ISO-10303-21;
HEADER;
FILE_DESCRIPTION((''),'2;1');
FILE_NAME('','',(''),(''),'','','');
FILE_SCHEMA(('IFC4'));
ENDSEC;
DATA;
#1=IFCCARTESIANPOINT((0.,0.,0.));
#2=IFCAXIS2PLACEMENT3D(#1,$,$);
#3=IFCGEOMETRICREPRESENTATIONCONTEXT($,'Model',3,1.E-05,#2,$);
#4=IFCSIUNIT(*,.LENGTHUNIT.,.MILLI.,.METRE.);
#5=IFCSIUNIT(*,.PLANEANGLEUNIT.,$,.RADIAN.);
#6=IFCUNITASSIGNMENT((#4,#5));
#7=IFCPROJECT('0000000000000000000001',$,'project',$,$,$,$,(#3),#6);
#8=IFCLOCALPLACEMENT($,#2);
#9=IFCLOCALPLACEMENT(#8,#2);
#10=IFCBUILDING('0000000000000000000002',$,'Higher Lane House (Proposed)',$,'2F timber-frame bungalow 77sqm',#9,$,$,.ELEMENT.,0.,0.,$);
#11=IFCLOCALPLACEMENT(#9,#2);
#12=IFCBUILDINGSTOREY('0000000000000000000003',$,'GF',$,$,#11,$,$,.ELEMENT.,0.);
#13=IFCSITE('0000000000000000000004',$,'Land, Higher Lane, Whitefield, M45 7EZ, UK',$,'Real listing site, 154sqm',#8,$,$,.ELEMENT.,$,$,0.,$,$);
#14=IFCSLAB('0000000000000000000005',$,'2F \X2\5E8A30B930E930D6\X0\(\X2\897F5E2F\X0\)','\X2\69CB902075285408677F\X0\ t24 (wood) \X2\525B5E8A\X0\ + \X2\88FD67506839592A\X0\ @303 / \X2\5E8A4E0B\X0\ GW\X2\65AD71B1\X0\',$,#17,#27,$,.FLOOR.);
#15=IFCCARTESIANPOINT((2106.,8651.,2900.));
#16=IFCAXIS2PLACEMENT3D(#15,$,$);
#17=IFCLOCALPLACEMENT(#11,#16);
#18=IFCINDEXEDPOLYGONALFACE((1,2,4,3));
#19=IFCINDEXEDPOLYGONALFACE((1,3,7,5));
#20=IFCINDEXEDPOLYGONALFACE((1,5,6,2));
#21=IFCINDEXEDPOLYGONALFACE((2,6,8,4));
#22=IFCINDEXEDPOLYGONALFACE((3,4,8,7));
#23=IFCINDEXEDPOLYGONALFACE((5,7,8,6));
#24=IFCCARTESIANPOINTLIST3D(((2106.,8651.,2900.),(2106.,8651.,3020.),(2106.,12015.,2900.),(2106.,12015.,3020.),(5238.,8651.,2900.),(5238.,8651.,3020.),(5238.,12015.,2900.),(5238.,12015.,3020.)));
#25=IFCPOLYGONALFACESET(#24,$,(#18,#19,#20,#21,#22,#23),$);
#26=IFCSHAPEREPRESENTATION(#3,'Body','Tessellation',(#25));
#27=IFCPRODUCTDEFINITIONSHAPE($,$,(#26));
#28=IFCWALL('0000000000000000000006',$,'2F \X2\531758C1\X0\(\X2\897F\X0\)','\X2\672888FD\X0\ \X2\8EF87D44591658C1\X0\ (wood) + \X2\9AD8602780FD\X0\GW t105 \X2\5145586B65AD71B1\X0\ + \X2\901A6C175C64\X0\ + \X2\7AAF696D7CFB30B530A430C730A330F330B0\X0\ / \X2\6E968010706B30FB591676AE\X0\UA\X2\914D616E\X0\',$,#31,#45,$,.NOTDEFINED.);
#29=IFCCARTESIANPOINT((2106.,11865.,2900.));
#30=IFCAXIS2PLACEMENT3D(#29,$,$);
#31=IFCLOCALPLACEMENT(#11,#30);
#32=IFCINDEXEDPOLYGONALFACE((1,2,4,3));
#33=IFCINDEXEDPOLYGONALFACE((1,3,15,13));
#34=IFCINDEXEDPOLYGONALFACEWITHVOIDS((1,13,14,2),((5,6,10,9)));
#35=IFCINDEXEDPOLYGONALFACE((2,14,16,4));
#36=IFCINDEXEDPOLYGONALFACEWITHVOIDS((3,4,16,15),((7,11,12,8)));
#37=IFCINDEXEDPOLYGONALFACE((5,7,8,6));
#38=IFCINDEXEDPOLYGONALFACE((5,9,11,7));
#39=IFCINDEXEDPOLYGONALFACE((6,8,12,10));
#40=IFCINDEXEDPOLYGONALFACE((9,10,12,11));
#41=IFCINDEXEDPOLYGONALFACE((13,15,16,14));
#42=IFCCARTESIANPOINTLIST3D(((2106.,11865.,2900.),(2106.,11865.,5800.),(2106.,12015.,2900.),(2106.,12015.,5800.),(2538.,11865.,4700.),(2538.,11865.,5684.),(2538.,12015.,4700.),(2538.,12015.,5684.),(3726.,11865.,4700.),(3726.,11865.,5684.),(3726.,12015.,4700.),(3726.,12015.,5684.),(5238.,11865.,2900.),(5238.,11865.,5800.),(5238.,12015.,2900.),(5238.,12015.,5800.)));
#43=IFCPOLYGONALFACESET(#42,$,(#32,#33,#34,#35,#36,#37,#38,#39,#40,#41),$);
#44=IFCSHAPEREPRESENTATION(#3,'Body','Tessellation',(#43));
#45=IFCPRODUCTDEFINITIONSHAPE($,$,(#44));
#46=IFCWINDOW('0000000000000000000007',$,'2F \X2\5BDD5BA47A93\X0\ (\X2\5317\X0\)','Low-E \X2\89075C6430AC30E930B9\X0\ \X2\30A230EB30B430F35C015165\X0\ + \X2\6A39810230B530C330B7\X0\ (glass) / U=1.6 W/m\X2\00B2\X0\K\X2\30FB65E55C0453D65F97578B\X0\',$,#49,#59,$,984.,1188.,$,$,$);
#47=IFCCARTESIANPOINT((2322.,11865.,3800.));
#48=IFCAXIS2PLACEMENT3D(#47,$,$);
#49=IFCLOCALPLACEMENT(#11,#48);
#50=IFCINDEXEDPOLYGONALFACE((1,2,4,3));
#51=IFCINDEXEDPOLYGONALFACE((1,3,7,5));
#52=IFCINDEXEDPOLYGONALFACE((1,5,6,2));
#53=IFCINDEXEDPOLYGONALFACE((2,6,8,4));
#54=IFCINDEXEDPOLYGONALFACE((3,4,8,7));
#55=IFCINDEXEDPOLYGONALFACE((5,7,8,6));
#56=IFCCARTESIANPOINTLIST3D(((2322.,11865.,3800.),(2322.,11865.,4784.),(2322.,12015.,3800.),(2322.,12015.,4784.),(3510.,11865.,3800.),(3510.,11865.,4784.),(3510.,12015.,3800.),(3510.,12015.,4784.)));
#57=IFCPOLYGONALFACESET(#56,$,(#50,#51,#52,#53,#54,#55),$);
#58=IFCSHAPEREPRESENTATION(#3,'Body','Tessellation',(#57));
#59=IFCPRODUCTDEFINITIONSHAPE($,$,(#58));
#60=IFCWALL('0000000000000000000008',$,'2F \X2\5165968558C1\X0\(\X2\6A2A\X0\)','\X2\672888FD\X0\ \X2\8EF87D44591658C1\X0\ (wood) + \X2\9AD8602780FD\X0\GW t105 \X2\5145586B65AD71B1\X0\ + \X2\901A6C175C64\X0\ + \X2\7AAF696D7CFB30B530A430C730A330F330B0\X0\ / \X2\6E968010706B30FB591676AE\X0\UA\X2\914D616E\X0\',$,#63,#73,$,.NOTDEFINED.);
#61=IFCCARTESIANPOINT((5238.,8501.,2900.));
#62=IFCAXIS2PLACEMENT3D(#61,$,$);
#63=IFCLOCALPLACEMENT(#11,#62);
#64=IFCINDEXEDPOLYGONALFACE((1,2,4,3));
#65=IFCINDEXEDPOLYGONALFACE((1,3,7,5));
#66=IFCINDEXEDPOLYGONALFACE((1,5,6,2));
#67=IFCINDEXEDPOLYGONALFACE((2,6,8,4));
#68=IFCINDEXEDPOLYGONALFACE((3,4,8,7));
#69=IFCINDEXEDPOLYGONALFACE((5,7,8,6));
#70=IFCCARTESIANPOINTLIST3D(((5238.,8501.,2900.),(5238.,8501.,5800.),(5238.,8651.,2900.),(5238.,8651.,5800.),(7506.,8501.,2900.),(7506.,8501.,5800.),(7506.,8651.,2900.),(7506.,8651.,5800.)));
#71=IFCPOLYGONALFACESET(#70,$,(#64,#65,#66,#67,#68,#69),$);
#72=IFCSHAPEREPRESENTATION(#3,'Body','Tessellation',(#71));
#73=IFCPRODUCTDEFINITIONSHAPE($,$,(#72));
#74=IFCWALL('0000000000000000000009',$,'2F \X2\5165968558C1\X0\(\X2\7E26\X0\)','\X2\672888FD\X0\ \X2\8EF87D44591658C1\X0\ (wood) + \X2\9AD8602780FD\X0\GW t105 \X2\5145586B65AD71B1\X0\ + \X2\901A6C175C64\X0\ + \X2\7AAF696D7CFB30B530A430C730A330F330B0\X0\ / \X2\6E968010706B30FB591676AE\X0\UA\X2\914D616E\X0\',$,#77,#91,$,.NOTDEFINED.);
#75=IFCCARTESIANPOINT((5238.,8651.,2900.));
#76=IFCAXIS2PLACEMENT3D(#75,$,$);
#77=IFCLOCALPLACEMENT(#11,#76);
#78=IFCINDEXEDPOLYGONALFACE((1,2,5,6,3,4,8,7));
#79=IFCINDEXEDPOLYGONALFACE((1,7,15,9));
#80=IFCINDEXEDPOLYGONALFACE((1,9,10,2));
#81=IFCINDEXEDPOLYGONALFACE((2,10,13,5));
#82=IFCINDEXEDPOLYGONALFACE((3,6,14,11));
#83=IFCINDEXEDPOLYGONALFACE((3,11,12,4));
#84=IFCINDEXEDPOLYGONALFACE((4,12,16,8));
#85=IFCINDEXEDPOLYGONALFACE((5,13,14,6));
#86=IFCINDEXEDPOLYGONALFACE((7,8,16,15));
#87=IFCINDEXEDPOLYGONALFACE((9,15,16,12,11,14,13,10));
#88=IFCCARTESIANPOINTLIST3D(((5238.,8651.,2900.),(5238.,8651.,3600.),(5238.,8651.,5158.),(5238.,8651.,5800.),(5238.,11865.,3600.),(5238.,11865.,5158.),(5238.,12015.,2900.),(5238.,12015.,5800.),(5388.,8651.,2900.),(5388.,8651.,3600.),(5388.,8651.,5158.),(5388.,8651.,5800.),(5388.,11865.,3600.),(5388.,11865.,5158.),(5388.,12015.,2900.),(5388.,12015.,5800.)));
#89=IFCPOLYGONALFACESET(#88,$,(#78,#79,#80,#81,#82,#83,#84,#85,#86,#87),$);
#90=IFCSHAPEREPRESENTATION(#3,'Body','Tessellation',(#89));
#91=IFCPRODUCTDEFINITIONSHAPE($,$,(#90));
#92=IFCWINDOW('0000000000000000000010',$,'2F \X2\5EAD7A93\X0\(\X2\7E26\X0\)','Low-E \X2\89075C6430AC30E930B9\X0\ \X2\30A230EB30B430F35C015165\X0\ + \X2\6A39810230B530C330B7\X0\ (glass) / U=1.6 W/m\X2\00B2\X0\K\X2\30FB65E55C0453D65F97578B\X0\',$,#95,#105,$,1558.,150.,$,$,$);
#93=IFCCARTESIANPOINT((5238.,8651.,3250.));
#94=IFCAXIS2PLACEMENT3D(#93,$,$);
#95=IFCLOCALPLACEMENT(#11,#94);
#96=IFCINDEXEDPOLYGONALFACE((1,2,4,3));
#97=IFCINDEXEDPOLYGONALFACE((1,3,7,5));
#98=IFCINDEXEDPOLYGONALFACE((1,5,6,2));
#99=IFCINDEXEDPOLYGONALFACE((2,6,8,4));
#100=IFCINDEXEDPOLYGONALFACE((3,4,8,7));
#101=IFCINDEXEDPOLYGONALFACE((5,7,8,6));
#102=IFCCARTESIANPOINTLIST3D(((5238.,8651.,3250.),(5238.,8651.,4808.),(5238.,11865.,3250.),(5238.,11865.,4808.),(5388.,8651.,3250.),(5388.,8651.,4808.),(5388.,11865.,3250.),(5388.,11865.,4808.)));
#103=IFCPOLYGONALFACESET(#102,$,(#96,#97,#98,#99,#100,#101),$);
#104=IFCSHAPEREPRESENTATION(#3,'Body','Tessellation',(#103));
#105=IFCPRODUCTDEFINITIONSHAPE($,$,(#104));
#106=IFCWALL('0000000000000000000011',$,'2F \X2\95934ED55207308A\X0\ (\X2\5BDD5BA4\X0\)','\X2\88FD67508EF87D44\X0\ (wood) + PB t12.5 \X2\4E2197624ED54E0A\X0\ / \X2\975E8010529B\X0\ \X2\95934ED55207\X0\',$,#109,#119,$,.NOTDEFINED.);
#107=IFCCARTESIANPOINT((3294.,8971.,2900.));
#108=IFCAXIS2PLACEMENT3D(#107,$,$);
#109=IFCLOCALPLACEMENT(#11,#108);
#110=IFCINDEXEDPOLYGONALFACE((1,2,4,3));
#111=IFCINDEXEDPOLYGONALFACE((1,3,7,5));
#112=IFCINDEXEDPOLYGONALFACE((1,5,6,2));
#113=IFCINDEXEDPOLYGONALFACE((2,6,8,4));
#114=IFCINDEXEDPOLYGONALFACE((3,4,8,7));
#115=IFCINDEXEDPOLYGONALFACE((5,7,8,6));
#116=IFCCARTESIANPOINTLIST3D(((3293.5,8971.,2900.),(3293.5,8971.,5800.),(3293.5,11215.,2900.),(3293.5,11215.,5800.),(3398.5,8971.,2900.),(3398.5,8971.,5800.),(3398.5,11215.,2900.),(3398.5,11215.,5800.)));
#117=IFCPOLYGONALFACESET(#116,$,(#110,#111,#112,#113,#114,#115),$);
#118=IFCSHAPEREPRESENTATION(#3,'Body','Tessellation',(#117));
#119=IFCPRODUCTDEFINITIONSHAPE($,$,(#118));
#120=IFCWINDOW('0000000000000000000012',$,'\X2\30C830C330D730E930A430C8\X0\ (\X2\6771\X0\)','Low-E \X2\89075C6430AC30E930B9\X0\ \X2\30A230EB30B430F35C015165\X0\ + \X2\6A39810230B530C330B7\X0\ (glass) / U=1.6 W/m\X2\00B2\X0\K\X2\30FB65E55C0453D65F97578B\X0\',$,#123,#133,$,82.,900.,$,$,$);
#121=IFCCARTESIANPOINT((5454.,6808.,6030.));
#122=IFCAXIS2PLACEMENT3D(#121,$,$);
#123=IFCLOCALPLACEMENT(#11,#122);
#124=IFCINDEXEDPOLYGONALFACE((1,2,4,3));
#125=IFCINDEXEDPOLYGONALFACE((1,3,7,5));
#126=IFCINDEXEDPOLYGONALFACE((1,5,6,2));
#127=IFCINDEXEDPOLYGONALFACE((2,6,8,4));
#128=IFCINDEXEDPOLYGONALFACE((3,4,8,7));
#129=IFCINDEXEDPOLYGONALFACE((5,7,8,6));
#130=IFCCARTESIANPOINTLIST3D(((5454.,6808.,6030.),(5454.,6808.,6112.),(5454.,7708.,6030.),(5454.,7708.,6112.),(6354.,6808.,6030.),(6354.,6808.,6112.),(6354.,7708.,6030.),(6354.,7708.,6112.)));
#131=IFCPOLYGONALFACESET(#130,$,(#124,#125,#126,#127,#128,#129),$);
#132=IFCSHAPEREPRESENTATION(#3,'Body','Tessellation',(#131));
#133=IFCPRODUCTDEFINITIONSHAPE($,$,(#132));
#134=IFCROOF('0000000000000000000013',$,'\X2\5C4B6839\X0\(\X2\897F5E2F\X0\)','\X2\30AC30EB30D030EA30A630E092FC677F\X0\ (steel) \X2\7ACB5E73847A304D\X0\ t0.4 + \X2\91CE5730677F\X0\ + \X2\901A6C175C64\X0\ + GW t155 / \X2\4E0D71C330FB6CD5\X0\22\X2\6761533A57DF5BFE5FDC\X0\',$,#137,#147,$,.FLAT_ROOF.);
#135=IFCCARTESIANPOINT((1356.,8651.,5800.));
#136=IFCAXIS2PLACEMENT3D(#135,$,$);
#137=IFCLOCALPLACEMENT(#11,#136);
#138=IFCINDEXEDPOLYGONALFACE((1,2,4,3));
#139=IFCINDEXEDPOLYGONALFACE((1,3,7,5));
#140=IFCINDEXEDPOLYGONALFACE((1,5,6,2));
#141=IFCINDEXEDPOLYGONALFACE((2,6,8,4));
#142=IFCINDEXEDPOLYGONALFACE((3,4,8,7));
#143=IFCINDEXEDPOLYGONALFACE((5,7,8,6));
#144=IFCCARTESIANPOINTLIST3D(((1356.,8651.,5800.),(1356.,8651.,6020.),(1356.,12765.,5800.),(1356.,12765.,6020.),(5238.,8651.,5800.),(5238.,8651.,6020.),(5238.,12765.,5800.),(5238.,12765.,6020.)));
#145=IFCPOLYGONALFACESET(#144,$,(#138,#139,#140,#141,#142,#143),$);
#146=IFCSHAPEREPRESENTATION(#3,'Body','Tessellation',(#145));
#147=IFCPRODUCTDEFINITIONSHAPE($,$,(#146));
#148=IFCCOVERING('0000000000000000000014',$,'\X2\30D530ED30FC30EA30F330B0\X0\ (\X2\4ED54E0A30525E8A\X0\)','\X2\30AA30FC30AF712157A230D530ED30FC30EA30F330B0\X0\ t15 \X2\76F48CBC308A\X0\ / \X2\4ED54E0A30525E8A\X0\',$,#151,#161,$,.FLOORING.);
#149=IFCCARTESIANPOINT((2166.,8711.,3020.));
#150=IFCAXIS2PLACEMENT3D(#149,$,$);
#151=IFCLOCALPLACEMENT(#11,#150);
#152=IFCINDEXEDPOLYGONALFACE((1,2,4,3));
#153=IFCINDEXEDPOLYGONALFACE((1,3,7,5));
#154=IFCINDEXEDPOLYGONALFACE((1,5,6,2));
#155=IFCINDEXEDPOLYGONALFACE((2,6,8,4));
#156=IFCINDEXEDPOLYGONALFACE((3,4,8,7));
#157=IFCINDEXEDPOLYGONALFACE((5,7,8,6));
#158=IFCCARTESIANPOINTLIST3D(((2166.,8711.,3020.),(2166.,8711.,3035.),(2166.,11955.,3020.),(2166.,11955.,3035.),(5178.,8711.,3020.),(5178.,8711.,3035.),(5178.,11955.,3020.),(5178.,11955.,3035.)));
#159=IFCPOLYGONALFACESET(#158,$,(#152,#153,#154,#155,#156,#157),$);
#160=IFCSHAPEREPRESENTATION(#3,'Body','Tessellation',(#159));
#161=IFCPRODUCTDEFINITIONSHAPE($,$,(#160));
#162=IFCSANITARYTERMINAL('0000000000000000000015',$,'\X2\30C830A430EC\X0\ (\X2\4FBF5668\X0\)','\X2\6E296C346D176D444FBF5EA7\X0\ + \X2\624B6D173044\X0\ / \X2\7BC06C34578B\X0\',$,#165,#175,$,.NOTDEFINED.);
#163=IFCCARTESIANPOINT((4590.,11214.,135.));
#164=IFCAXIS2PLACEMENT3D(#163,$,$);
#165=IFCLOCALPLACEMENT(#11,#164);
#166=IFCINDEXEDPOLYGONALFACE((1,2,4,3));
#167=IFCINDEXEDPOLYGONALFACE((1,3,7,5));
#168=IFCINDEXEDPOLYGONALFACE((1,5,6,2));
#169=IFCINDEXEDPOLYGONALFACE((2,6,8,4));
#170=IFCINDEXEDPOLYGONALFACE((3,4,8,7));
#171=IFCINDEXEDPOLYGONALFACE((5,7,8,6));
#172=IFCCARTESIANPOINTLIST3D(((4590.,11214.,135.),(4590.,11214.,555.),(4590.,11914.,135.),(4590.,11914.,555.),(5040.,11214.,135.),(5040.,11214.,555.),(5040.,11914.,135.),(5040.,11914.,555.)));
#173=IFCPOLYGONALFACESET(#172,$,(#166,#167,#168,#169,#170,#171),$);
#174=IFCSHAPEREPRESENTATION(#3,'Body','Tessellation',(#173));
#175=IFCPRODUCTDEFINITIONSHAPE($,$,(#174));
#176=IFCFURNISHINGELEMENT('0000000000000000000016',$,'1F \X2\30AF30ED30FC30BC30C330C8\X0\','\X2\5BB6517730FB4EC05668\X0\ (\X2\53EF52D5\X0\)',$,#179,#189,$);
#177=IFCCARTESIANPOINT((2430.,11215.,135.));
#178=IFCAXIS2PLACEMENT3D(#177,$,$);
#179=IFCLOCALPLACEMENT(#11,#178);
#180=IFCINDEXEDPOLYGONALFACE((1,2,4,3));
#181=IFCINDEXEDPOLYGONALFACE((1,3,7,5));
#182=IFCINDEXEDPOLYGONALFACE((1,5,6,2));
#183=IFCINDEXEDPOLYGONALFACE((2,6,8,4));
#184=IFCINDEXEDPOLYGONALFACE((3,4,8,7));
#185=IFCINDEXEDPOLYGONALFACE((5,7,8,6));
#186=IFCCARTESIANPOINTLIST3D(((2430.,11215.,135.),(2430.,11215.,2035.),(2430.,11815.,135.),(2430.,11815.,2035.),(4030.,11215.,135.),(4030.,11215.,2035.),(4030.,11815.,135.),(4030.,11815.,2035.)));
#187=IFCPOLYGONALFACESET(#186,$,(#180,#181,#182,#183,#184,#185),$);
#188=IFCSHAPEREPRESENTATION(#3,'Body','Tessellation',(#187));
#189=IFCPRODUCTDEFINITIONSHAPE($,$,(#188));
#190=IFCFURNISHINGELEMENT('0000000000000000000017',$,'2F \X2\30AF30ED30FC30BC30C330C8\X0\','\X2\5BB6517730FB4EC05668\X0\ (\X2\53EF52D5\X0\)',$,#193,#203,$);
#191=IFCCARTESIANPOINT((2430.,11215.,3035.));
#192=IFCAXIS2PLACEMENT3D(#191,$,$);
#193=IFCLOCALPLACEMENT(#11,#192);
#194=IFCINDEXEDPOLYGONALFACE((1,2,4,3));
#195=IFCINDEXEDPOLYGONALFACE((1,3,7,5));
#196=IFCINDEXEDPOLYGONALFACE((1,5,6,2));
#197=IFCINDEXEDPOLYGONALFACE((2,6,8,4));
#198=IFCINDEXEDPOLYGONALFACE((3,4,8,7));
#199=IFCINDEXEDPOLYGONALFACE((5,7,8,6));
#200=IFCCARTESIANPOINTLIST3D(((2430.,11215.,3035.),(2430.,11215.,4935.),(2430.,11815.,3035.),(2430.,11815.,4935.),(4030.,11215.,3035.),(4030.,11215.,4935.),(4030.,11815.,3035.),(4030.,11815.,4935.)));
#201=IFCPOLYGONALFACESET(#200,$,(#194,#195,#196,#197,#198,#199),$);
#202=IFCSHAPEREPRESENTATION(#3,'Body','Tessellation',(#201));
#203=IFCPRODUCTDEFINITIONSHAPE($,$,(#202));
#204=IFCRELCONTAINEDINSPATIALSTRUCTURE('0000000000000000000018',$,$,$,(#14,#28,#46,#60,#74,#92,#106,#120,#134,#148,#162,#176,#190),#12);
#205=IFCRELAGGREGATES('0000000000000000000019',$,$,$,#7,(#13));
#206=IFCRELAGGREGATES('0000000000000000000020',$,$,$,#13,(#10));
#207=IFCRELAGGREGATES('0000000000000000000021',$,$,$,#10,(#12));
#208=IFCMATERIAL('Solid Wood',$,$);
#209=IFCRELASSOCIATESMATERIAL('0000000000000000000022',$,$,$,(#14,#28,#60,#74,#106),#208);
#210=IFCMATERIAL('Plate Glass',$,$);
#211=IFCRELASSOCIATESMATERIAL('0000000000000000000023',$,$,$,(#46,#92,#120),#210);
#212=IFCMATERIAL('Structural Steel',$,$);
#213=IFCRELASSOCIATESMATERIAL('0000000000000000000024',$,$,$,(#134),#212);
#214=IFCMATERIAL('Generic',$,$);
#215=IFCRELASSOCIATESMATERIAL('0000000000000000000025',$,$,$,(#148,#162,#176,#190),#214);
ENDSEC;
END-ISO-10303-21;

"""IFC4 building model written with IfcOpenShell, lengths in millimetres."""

from ifc_helpers import new_model, si_unit, frame, frame_2d, origin, place, context, project, spatial, rectangle, extrude, material, element, fill, save


model = new_model("IFC4")

# Units and contexts
model_context = context("Model", 3, precision=1e-05, world=origin())
ifc_project = project(units=[si_unit("LENGTHUNIT", "METRE", prefix="MILLI"), si_unit("PLANEANGLEUNIT", "RADIAN")], contexts=[model_context])

# Site, building, storey
site_placement = place(None, origin())
site = spatial("IfcSite", under=ifc_project, at=site_placement, Name="Land, Higher Lane, Whitefield, M45 7EZ, UK", ObjectType="Real listing site, 154sqm", CompositionType="ELEMENT", RefElevation=0.0)
building_placement = place(site_placement, origin())
building = spatial("IfcBuilding", under=site, at=building_placement, Name="Higher Lane House (Proposed)", ObjectType="2F timber-frame bungalow 77sqm", CompositionType="ELEMENT", ElevationOfRefHeight=0.0, ElevationOfTerrain=0.0)
storey_placement = place(building_placement, origin())
storey = spatial("IfcBuildingStorey", under=building, at=storey_placement, Name="GF", CompositionType="ELEMENT", Elevation=0.0)

# Slab
ifc_material_1 = material(Name="Solid Wood")
slab_placement = place(storey_placement, frame((2106.0, 8651.0, 2900.0)))
element("IfcSlab", 1, at=slab_placement, inside=storey, material=ifc_material_1, Name="2F 床スラブ(西帯)", Description="構造用合板 t24 (wood) 剛床 + 製材根太 @303 / 床下 GW断熱", PredefinedType="FLOOR", context=model_context, shape_type="SweptSolid", body=[
    extrude(rectangle(XDim=3132.0, YDim=3364.0, at=frame_2d((1566.0, 1682.0))), frame((2106.0, 8651.0, 2900.0)), (0.0, 0.0, 1.0), 120.0),
])

# Wall, opening, window
wall_1_placement = place(storey_placement, frame((2106.0, 11865.0, 2900.0)))
wall_1 = element("IfcWall", 2, at=wall_1_placement, inside=storey, material=ifc_material_1, Name="2F 北壁(西)", Description="木製 軸組外壁 (wood) + 高性能GW t105 充填断熱 + 通気層 + 窯業系サイディング / 準耐火・外皮UA配慮", PredefinedType="NOTDEFINED", context=model_context, shape_type="SweptSolid", body=[
    extrude(rectangle(XDim=3132.0, YDim=150.0, at=frame_2d((1566.0, 75.0))), frame((2106.0, 11865.0, 2900.0)), (0.0, 0.0, 1.0), 2900.0),
])
opening_1_placement = place(storey_placement, frame((2322.0, 11865.0, 3800.0)))
opening_1 = element("IfcOpeningElement", 3, at=opening_1_placement, cuts=wall_1, PredefinedType="NOTDEFINED", context=model_context, shape_type="SweptSolid", body=[
    extrude(rectangle(XDim=1188.0, YDim=150.0, at=frame_2d((594.0, 75.0))), frame((2322.0, 11865.0, 3800.0)), (0.0, 0.0, 1.0), 984.0),
])
ifc_material_2 = material(Name="Plate Glass")
window_1_placement = place(storey_placement, frame((2322.0, 11865.0, 3800.0)))
window_1 = element("IfcWindow", 4, at=window_1_placement, inside=storey, material=ifc_material_2, Name="2F 寝室窓 (北)", Description="Low-E 複層ガラス アルゴン封入 + 樹脂サッシ (glass) / U=1.6 W/m²K・日射取得型", OverallHeight=984.0, OverallWidth=1188.0, context=model_context, shape_type="SweptSolid", body=[
    extrude(rectangle(XDim=1188.0, YDim=150.0, at=frame_2d((594.0, 75.0))), frame((2322.0, 11865.0, 3800.0)), (0.0, 0.0, 1.0), 984.0),
])
fill(opening_1, window_1)

# Wall
wall_2_placement = place(storey_placement, frame((5238.0, 8501.0, 2900.0)))
element("IfcWall", 5, at=wall_2_placement, inside=storey, material=ifc_material_1, Name="2F 入隅壁(横)", Description="木製 軸組外壁 (wood) + 高性能GW t105 充填断熱 + 通気層 + 窯業系サイディング / 準耐火・外皮UA配慮", PredefinedType="NOTDEFINED", context=model_context, shape_type="SweptSolid", body=[
    extrude(rectangle(XDim=2268.0, YDim=150.0, at=frame_2d((1134.0, 75.0))), frame((5238.0, 8501.0, 2900.0)), (0.0, 0.0, 1.0), 2900.0),
])

# Wall, opening, window
wall_3_placement = place(storey_placement, frame((5238.0, 8651.0, 2900.0)))
wall_3 = element("IfcWall", 6, at=wall_3_placement, inside=storey, material=ifc_material_1, Name="2F 入隅壁(縦)", Description="木製 軸組外壁 (wood) + 高性能GW t105 充填断熱 + 通気層 + 窯業系サイディング / 準耐火・外皮UA配慮", PredefinedType="NOTDEFINED", context=model_context, shape_type="SweptSolid", body=[
    extrude(rectangle(XDim=150.0, YDim=3364.0, at=frame_2d((75.0, 1682.0))), frame((5238.0, 8651.0, 2900.0)), (0.0, 0.0, 1.0), 2900.0),
])
opening_2_placement = place(storey_placement, frame((5238.0, 8651.0, 3250.0)))
opening_2 = element("IfcOpeningElement", 7, at=opening_2_placement, cuts=wall_3, PredefinedType="NOTDEFINED", context=model_context, shape_type="SweptSolid", body=[
    extrude(rectangle(XDim=150.0, YDim=3214.0, at=frame_2d((75.0, 1607.0))), frame((5238.0, 8651.0, 3250.0)), (0.0, 0.0, 1.0), 1558.0),
])
window_2_placement = place(storey_placement, frame((5238.0, 8651.0, 3250.0)))
window_2 = element("IfcWindow", 8, at=window_2_placement, inside=storey, material=ifc_material_2, Name="2F 庭窓(縦)", Description="Low-E 複層ガラス アルゴン封入 + 樹脂サッシ (glass) / U=1.6 W/m²K・日射取得型", OverallHeight=1558.0, OverallWidth=150.0, context=model_context, shape_type="SweptSolid", body=[
    extrude(rectangle(XDim=150.0, YDim=3214.0, at=frame_2d((75.0, 1607.0))), frame((5238.0, 8651.0, 3250.0)), (0.0, 0.0, 1.0), 1558.0),
])
fill(opening_2, window_2)

# Wall
wall_4_placement = place(storey_placement, frame((3294.0, 8971.0, 2900.0)))
element("IfcWall", 9, at=wall_4_placement, inside=storey, material=ifc_material_1, Name="2F 間仕切り (寝室)", Description="製材軸組 (wood) + PB t12.5 両面仕上 / 非耐力 間仕切", PredefinedType="NOTDEFINED", context=model_context, shape_type="SweptSolid", body=[
    extrude(rectangle(XDim=105.0, YDim=2244.0, at=frame_2d((52.0, 1122.0))), frame((3294.0, 8971.0, 2900.0)), (0.0, 0.0, 1.0), 2900.0),
])

# Window
window_3_placement = place(storey_placement, frame((5454.0, 6808.0, 6030.0)))
element("IfcWindow", 10, at=window_3_placement, inside=storey, material=ifc_material_2, Name="トップライト (東)", Description="Low-E 複層ガラス アルゴン封入 + 樹脂サッシ (glass) / U=1.6 W/m²K・日射取得型", OverallHeight=82.0, OverallWidth=900.0, context=model_context, shape_type="SweptSolid", body=[
    extrude(rectangle(XDim=900.0, YDim=900.0, at=frame_2d((450.0, 450.0))), frame((5454.0, 6808.0, 6030.0)), (0.0, 0.0, 1.0), 82.0),
])

# Roof
ifc_material_3 = material(Name="Structural Steel")
for number, where, name in (
    (11, (1356.0, 8651.0, 5800.0), "屋根(西帯)"),
):
    element("IfcRoof", number, at=place(storey_placement, frame(where)), inside=storey, material=ifc_material_3, Name=name, Description="ガルバリウム鋼板 (steel) 立平葺き t0.4 + 野地板 + 通気層 + GW t155 / 不燃・法22条区域対応", PredefinedType="FLAT_ROOF", context=model_context, shape_type="SweptSolid", body=[
        extrude(rectangle(XDim=3882.0, YDim=4114.0, at=frame_2d((1941.0, 2057.0))), frame((1356.0, 8651.0, 5800.0)), (0.0, 0.0, 1.0), 220.0),
    ])

# Covering
ifc_material_4 = material(Name="Generic")
covering_placement = place(storey_placement, frame((2166.0, 8711.0, 3020.0)))
element("IfcCovering", 12, at=covering_placement, inside=storey, material=ifc_material_4, Name="フローリング (仕上げ床)", Description="オーク無垢フローリング t15 直貼り / 仕上げ床", PredefinedType="FLOORING", context=model_context, shape_type="SweptSolid", body=[
    extrude(rectangle(XDim=3012.0, YDim=3244.0, at=frame_2d((1506.0, 1622.0))), frame((2166.0, 8711.0, 3020.0)), (0.0, 0.0, 1.0), 15.0),
])

# Sanitary terminal
sanitary_terminal_placement = place(storey_placement, frame((4590.0, 11214.0, 135.0)))
element("IfcSanitaryTerminal", 13, at=sanitary_terminal_placement, inside=storey, material=ifc_material_4, Name="トイレ (便器)", Description="温水洗浄便座 + 手洗い / 節水型", PredefinedType="NOTDEFINED", context=model_context, shape_type="SweptSolid", body=[
    extrude(rectangle(XDim=450.0, YDim=700.0, at=frame_2d((225.0, 350.0))), frame((4590.0, 11214.0, 135.0)), (0.0, 0.0, 1.0), 420.0),
])

# Furnishing elements
furnishing_1_placement = place(storey_placement, frame((2430.0, 11215.0, 135.0)))
element("IfcFurnishingElement", 14, at=furnishing_1_placement, inside=storey, material=ifc_material_4, Name="1F クローゼット", Description="家具・什器 (可動)", context=model_context, shape_type="SweptSolid", body=[
    extrude(rectangle(XDim=1600.0, YDim=600.0, at=frame_2d((800.0, 300.0))), frame((2430.0, 11215.0, 135.0)), (0.0, 0.0, 1.0), 1900.0),
])
furnishing_2_placement = place(storey_placement, frame((2430.0, 11215.0, 3035.0)))
element("IfcFurnishingElement", 15, at=furnishing_2_placement, inside=storey, material=ifc_material_4, Name="2F クローゼット", Description="家具・什器 (可動)", context=model_context, shape_type="SweptSolid", body=[
    extrude(rectangle(XDim=1600.0, YDim=600.0, at=frame_2d((800.0, 300.0))), frame((2430.0, 11215.0, 3035.0)), (0.0, 0.0, 1.0), 1900.0),
])

save(model, "model.ifc")
